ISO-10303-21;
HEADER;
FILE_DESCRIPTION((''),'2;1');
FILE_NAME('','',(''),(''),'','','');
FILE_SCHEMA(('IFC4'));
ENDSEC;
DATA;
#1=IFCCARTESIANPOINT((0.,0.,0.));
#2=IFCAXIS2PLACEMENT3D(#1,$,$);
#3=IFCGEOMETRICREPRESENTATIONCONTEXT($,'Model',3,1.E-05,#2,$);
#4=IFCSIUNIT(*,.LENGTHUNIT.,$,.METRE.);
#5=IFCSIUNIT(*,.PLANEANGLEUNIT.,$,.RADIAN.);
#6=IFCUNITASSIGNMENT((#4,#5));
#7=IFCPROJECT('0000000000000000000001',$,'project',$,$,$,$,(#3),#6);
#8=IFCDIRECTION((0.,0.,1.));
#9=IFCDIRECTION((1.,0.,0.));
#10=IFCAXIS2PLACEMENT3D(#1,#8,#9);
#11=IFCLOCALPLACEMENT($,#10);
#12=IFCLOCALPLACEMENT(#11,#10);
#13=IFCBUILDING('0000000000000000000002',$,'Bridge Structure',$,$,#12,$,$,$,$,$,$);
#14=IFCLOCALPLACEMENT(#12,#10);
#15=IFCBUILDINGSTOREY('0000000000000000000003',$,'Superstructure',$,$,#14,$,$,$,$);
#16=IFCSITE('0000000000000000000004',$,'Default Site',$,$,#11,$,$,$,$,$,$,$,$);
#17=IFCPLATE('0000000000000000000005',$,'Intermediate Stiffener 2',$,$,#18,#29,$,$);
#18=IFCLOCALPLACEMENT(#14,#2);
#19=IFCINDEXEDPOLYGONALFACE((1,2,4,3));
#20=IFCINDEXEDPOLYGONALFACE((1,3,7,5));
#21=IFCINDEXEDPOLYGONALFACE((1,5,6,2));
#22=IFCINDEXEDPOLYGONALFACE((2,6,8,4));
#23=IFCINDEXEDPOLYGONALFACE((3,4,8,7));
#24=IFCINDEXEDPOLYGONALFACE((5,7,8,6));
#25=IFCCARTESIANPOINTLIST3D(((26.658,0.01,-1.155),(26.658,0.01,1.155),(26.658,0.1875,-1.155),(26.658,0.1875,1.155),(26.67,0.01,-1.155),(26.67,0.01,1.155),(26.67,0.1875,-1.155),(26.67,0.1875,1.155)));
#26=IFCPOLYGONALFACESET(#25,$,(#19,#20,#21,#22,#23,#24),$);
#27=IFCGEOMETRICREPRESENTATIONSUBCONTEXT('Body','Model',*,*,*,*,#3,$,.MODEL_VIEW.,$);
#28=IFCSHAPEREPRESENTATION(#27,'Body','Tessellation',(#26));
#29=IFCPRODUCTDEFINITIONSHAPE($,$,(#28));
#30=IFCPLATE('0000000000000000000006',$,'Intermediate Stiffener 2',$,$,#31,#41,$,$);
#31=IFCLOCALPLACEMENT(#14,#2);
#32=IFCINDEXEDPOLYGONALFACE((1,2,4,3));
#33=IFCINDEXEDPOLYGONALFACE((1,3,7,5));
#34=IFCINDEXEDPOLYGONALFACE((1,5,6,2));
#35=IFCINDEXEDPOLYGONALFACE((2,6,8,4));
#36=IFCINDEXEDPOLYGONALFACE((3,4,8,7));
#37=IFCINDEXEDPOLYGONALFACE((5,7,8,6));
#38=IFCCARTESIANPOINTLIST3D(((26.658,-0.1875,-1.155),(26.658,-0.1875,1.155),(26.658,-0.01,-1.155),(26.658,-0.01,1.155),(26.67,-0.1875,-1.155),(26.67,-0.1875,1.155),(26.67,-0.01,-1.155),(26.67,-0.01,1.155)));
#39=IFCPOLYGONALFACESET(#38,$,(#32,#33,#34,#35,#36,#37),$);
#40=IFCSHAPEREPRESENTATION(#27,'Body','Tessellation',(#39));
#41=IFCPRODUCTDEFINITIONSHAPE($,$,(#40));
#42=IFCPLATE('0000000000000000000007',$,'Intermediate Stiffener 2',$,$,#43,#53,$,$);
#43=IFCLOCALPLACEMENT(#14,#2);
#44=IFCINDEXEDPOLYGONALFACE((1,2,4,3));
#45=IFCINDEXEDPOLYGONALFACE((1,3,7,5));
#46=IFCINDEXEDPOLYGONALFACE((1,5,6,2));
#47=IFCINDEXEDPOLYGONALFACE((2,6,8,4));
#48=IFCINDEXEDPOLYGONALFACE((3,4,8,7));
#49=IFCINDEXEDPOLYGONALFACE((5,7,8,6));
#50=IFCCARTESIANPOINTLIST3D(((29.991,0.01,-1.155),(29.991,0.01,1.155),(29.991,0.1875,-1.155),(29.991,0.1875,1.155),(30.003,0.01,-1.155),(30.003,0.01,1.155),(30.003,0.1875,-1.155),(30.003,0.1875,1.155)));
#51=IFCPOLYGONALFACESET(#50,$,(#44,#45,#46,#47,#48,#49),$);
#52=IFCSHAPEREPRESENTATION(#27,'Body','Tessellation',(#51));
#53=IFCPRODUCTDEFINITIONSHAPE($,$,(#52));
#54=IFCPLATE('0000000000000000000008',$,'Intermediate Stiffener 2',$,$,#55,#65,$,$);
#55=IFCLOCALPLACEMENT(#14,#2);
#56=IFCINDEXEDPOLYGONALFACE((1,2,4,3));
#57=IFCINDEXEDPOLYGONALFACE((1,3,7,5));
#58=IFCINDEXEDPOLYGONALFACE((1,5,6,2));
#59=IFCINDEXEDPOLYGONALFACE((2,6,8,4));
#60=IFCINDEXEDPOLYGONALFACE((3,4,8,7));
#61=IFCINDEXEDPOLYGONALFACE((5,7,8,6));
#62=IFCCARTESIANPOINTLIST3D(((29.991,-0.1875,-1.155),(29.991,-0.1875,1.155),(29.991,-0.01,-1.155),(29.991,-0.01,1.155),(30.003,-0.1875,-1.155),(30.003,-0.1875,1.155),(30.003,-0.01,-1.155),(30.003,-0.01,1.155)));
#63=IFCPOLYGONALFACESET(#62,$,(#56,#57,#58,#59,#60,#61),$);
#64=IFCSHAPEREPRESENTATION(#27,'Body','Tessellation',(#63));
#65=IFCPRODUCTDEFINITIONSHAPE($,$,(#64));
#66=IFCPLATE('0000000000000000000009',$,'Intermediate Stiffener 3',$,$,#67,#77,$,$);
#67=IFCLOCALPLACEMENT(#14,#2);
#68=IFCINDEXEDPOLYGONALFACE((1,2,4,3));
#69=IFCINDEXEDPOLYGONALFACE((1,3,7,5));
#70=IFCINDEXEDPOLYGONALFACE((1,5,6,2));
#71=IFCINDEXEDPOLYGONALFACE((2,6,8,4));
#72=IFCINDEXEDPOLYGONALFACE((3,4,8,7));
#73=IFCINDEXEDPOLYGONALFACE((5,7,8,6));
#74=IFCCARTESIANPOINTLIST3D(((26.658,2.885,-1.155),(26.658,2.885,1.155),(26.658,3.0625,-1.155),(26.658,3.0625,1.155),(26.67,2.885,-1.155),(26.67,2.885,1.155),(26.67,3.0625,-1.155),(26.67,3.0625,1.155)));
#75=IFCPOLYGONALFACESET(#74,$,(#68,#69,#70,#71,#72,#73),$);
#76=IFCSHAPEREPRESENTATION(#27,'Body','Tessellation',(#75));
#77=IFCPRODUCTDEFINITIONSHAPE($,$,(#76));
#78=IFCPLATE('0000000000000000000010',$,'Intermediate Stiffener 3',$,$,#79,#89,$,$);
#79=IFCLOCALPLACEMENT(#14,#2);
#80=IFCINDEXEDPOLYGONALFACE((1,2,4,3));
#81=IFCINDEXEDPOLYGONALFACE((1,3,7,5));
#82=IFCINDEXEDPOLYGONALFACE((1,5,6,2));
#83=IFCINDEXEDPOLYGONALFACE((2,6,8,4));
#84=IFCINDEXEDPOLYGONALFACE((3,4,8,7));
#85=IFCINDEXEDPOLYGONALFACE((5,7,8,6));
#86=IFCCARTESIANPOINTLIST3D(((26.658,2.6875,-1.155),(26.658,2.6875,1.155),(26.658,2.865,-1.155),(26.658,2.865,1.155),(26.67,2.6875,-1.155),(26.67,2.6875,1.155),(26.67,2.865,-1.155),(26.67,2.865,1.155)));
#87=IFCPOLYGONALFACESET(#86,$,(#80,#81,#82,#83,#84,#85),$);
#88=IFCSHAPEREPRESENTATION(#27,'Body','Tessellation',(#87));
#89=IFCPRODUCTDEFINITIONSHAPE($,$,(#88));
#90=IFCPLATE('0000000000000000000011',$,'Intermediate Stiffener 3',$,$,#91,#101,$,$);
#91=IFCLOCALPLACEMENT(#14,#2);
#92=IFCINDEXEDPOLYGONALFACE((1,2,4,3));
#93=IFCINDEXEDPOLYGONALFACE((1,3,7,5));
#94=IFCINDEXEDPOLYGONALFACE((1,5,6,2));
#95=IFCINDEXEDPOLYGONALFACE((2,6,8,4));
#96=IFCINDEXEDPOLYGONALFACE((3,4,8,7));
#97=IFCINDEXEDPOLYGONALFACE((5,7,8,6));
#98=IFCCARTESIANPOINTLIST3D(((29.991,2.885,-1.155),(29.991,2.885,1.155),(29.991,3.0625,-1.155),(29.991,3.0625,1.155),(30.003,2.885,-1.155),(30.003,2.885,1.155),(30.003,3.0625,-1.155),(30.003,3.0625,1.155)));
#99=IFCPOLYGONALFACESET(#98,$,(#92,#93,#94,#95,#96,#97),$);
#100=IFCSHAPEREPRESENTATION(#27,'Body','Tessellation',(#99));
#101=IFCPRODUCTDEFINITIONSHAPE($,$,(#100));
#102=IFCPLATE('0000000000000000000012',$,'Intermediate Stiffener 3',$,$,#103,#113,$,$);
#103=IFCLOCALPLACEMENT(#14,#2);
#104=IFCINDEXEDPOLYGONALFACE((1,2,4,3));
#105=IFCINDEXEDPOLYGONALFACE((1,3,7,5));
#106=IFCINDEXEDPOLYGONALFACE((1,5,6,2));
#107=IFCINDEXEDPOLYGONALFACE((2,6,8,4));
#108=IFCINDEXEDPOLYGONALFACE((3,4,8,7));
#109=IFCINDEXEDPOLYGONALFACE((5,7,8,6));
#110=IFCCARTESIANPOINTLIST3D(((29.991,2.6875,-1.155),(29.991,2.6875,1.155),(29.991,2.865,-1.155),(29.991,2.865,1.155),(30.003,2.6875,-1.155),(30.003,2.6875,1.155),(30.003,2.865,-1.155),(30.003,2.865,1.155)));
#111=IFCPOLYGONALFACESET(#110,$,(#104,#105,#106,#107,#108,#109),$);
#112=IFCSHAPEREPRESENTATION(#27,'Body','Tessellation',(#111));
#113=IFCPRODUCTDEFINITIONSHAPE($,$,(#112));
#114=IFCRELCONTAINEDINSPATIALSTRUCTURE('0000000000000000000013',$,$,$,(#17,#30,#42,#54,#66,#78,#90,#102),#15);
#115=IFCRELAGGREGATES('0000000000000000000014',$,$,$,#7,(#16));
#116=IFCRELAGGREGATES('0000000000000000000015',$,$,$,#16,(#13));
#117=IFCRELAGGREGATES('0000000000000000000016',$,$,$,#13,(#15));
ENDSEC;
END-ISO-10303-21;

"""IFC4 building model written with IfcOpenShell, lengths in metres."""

from ifc_helpers import new_model, si_unit, frame, origin, origin_with_axes, origin_2d_with_axis, place, context, subcontext, project, spatial, rectangle, extrude, element, save


model = new_model("IFC4")

# Units and contexts
model_context = context("Model", 3, precision=1e-05, world=origin())
body_context = subcontext(model_context, "Body", "Model", "MODEL_VIEW")
ifc_project = project(units=[si_unit("LENGTHUNIT", "METRE"), si_unit("PLANEANGLEUNIT", "RADIAN")], contexts=[model_context])

# Site, building, storey
site_placement = place(None, origin_with_axes())
site = spatial("IfcSite", under=ifc_project, at=site_placement, Name="Default Site")
building_placement = place(site_placement, origin_with_axes())
building = spatial("IfcBuilding", under=site, at=building_placement, Name="Bridge Structure")
storey_placement = place(building_placement, origin_with_axes())
storey = spatial("IfcBuildingStorey", under=building, at=storey_placement, Name="Superstructure")

# Plates
for number, where, z_axis, x_axis, name in (
    (1, (26.664, 0.0988, -1.155), (0.0, 0.0, 1.0), (1.0, 0.0, 0.0), "Intermediate Stiffener 2"),
    (2, (26.664, -0.0988, -1.155), (0.0, 0.0, 1.0), (1.0, 0.0, 0.0), "Intermediate Stiffener 2"),
    (3, (29.997, 0.0988, -1.155), (0.0, 0.0, 1.0), (1.0, 0.0, 0.0), "Intermediate Stiffener 2"),
    (4, (29.997, -0.0988, -1.155), (0.0, 0.0, 1.0), (1.0, 0.0, 0.0), "Intermediate Stiffener 2"),
    (5, (26.664, 2.9737, -1.155), (0.0, 0.0, 1.0), (1.0, 0.0, 0.0), "Intermediate Stiffener 3"),
    (6, (26.664, 2.7763, -1.155), (0.0, 0.0, 1.0), (1.0, 0.0, 0.0), "Intermediate Stiffener 3"),
    (7, (29.997, 2.9737, -1.155), (0.0, 0.0, 1.0), (1.0, 0.0, 0.0), "Intermediate Stiffener 3"),
    (8, (29.997, 2.7763, -1.155), (0.0, 0.0, 1.0), (1.0, 0.0, 0.0), "Intermediate Stiffener 3"),
):
    element("IfcPlate", number, at=place(storey_placement, frame(where, z_axis=z_axis, x_axis=x_axis)), inside=storey, Name=name, context=body_context, shape_type="SweptSolid", body=[
        extrude(rectangle(XDim=0.012, YDim=0.1775, at=origin_2d_with_axis()), origin_with_axes(), (0.0, 0.0, 1.0), 2.31),
    ])

save(model, "model.ifc")
